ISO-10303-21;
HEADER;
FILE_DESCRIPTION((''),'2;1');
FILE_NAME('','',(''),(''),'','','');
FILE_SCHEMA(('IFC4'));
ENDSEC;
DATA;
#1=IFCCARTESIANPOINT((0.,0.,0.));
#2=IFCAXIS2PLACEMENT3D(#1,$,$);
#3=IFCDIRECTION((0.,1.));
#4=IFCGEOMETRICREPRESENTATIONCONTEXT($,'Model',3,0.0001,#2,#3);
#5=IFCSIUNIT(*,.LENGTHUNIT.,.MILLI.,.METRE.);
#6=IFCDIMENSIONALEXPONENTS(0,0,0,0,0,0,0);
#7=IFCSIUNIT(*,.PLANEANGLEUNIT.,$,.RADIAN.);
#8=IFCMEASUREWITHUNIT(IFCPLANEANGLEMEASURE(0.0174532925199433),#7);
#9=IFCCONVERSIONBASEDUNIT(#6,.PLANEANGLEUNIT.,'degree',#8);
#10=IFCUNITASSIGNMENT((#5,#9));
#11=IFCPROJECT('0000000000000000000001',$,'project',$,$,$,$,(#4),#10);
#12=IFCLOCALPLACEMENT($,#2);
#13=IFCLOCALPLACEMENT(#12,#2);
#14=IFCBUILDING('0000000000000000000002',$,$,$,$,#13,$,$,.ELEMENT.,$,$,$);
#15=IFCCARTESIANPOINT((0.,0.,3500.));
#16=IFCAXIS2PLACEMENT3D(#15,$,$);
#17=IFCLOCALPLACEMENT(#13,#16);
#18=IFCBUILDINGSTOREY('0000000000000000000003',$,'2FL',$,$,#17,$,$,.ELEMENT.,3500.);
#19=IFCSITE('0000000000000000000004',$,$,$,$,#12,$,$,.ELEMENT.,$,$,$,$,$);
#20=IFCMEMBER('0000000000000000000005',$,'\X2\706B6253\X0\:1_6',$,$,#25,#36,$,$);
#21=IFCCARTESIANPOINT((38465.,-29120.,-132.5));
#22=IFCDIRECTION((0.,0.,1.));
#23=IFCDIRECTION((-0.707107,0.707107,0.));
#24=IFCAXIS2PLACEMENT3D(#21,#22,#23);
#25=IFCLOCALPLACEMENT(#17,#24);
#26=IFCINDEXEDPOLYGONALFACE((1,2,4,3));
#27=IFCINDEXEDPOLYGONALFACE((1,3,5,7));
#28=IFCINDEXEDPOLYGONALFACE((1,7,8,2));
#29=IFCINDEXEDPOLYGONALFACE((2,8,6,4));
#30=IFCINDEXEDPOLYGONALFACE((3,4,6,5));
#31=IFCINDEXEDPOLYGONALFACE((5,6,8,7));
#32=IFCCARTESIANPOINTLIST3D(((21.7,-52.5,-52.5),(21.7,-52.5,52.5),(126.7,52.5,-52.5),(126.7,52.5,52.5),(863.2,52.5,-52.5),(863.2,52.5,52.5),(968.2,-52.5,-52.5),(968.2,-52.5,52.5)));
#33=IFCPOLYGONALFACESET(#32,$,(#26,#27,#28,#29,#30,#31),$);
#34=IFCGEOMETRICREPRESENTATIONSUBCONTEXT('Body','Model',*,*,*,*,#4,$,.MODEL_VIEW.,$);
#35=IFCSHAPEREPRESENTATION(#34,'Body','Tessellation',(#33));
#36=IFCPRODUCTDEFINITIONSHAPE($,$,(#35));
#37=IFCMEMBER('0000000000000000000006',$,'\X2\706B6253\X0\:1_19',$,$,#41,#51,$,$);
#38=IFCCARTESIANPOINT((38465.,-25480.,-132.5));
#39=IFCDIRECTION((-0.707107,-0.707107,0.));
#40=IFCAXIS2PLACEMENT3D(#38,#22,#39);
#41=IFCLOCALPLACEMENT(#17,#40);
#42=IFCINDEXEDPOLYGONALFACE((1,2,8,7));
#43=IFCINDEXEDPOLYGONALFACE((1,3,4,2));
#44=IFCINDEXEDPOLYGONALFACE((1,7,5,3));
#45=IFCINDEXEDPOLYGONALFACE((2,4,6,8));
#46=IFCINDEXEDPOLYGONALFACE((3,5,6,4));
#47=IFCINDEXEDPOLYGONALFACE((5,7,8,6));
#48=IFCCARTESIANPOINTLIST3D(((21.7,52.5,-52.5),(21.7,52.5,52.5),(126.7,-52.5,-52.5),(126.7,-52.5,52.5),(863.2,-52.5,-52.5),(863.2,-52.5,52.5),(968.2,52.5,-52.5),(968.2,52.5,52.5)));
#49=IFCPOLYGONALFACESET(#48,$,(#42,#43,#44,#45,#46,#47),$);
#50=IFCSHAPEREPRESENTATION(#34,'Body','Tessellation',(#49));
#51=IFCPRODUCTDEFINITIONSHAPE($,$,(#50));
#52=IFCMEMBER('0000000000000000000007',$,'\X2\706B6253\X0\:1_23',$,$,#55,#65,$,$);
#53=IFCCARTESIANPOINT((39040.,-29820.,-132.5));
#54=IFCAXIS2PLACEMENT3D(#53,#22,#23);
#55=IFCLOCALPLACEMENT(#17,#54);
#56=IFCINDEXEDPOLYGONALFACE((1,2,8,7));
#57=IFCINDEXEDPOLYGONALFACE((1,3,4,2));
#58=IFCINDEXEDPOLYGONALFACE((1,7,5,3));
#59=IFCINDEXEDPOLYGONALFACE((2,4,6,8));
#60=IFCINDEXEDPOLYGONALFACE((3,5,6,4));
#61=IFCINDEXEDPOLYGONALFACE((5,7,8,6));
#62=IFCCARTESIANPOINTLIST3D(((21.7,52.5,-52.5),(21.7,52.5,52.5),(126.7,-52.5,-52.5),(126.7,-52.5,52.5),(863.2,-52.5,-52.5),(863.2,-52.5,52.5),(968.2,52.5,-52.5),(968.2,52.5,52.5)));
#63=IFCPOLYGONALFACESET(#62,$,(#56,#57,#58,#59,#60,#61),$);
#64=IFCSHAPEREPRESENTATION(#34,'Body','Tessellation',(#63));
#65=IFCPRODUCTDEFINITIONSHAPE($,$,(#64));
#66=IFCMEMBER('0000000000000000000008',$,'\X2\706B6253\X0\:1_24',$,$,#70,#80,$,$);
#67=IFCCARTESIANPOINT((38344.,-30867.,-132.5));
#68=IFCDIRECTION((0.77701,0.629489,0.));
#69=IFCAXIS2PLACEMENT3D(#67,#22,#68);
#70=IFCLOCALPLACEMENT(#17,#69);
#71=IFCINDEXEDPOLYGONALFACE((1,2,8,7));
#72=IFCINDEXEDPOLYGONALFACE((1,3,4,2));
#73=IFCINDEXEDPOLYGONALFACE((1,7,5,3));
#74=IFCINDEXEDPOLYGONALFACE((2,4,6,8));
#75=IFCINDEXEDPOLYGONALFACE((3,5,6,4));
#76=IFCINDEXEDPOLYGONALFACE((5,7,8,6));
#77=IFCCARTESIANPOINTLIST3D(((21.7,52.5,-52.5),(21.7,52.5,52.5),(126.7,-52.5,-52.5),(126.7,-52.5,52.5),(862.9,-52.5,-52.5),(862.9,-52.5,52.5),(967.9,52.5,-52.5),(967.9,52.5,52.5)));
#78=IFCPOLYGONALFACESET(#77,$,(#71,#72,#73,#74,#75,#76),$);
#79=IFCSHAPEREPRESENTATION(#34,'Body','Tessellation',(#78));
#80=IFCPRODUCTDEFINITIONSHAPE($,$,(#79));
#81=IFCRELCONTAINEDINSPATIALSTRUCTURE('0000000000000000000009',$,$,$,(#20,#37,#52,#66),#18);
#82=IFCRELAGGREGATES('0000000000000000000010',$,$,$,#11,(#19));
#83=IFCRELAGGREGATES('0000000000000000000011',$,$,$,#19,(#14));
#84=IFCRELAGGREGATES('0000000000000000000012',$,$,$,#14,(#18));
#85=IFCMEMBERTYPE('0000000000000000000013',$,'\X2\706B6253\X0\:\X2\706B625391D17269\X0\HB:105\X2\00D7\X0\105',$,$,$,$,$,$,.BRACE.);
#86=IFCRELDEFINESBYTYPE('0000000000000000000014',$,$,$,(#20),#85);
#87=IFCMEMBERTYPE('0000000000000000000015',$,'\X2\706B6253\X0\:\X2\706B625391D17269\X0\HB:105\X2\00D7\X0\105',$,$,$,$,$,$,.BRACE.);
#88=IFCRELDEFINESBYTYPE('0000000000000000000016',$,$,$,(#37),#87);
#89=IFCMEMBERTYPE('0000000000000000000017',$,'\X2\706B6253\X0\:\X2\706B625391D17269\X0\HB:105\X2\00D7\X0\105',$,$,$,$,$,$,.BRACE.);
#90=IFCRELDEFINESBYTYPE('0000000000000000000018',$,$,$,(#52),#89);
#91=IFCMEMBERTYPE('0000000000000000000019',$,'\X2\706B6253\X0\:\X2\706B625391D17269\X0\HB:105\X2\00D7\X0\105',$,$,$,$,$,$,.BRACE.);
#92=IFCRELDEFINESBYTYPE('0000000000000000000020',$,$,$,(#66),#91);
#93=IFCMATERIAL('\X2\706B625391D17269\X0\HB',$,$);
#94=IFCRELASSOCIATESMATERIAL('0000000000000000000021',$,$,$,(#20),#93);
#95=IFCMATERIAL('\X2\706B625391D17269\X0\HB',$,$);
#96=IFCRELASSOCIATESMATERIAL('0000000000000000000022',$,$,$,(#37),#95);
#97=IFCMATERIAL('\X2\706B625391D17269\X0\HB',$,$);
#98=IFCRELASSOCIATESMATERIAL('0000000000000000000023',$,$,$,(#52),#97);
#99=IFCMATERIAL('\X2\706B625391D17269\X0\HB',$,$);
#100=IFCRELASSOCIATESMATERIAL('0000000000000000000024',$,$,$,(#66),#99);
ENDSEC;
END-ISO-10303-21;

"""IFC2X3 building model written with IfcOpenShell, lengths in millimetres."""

from ifc_helpers import new_model, entity, si_unit, converted_unit, direction, frame, origin, place, context, subcontext, project, spatial, polyline, outline, extrude, material, type_object, element, save


model = new_model("IFC2X3")

# Units and contexts
model_context = context("Model", 3, precision=0.0001, world=origin(), true_north=direction((0.0, 1.0)))
body_context = subcontext(model_context, "Body", "Model", "MODEL_VIEW")
ifc_project = project(units=[si_unit("LENGTHUNIT", "METRE", prefix="MILLI"), converted_unit("PLANEANGLEUNIT", "degree", entity("IfcPlaneAngleMeasure", 0.0174532925199433), si_unit("PLANEANGLEUNIT", "RADIAN"), dimensions=[0, 0, 0, 0, 0, 0, 0])], contexts=[model_context])

# Site, building, storey
site_placement = place(None, origin())
site = spatial("IfcSite", under=ifc_project, at=site_placement, CompositionType="ELEMENT")
building_placement = place(site_placement, origin())
building = spatial("IfcBuilding", under=site, at=building_placement, CompositionType="ELEMENT")
storey_placement = place(building_placement, frame((0.0, 0.0, 3500.0)))
storey = spatial("IfcBuildingStorey", under=building, at=storey_placement, Name="2FL", CompositionType="ELEMENT", Elevation=3500.0)

# Members
ifc_material_1 = material(Name="火打金物HB")
member_type_1 = type_object("IfcMemberType", Name="火打:火打金物HB:105×105", PredefinedType="BRACE")
member_1_placement = place(storey_placement, frame((38465.0, -29120.0, -132.5), z_axis=(0.0, 0.0, 1.0), x_axis=(-0.707107, 0.707107, 0.0)))
element("IfcMember", 1, at=member_1_placement, inside=storey, type_object=member_type_1, material=ifc_material_1, Name="火打:1_6", context=body_context, shape_type="SweptSolid", body=[
    extrude(outline(polyline([(21.7, -52.5, 0.0), (126.7, 52.5, 0.0), (863.2, 52.5, 0.0), (968.2, -52.5, 0.0), (21.7, -52.5, 0.0)])), frame((0.0, 0.0, -52.5), z_axis=(0.0, 0.0, 1.0), x_axis=(1.0, 0.0, 0.0)), (0.0, 0.0, 1.0), 105.0),
])
ifc_material_2 = material(Name="火打金物HB")
member_type_2 = type_object("IfcMemberType", Name="火打:火打金物HB:105×105", PredefinedType="BRACE")
member_2_placement = place(storey_placement, frame((38465.0, -25480.0, -132.5), z_axis=(0.0, 0.0, 1.0), x_axis=(-0.707107, -0.707107, 0.0)))
element("IfcMember", 2, at=member_2_placement, inside=storey, type_object=member_type_2, material=ifc_material_2, Name="火打:1_19", context=body_context, shape_type="SweptSolid", body=[
    extrude(outline(polyline([(126.7, -52.5, 0.0), (21.7, 52.5, 0.0), (968.2, 52.5, 0.0), (863.2, -52.5, 0.0), (126.7, -52.5, 0.0)])), frame((0.0, 0.0, -52.5), z_axis=(0.0, 0.0, 1.0), x_axis=(1.0, 0.0, 0.0)), (0.0, 0.0, 1.0), 105.0),
])
ifc_material_3 = material(Name="火打金物HB")
member_type_3 = type_object("IfcMemberType", Name="火打:火打金物HB:105×105", PredefinedType="BRACE")
member_3_placement = place(storey_placement, frame((39040.0, -29820.0, -132.5), z_axis=(0.0, 0.0, 1.0), x_axis=(-0.707107, 0.707107, 0.0)))
element("IfcMember", 3, at=member_3_placement, inside=storey, type_object=member_type_3, material=ifc_material_3, Name="火打:1_23", context=body_context, shape_type="SweptSolid", body=[
    extrude(outline(polyline([(126.7, -52.5, 0.0), (21.7, 52.5, 0.0), (968.2, 52.5, 0.0), (863.2, -52.5, 0.0), (126.7, -52.5, 0.0)])), frame((0.0, 0.0, -52.5), z_axis=(0.0, 0.0, 1.0), x_axis=(1.0, 0.0, 0.0)), (0.0, 0.0, 1.0), 105.0),
])
ifc_material_4 = material(Name="火打金物HB")
member_type_4 = type_object("IfcMemberType", Name="火打:火打金物HB:105×105", PredefinedType="BRACE")
member_4_placement = place(storey_placement, frame((38344.0, -30867.0, -132.5), z_axis=(0.0, 0.0, 1.0), x_axis=(0.77701, 0.629489, 0.0)))
element("IfcMember", 4, at=member_4_placement, inside=storey, type_object=member_type_4, material=ifc_material_4, Name="火打:1_24", context=body_context, shape_type="SweptSolid", body=[
    extrude(outline(polyline([(126.7, -52.5, 0.0), (21.7, 52.5, 0.0), (967.9, 52.5, 0.0), (862.9, -52.5, 0.0), (126.7, -52.5, 0.0)])), frame((0.0, 0.0, -52.5), z_axis=(0.0, 0.0, 1.0), x_axis=(1.0, 0.0, 0.0)), (0.0, 0.0, 1.0), 105.0),
])

save(model, "model.ifc")
